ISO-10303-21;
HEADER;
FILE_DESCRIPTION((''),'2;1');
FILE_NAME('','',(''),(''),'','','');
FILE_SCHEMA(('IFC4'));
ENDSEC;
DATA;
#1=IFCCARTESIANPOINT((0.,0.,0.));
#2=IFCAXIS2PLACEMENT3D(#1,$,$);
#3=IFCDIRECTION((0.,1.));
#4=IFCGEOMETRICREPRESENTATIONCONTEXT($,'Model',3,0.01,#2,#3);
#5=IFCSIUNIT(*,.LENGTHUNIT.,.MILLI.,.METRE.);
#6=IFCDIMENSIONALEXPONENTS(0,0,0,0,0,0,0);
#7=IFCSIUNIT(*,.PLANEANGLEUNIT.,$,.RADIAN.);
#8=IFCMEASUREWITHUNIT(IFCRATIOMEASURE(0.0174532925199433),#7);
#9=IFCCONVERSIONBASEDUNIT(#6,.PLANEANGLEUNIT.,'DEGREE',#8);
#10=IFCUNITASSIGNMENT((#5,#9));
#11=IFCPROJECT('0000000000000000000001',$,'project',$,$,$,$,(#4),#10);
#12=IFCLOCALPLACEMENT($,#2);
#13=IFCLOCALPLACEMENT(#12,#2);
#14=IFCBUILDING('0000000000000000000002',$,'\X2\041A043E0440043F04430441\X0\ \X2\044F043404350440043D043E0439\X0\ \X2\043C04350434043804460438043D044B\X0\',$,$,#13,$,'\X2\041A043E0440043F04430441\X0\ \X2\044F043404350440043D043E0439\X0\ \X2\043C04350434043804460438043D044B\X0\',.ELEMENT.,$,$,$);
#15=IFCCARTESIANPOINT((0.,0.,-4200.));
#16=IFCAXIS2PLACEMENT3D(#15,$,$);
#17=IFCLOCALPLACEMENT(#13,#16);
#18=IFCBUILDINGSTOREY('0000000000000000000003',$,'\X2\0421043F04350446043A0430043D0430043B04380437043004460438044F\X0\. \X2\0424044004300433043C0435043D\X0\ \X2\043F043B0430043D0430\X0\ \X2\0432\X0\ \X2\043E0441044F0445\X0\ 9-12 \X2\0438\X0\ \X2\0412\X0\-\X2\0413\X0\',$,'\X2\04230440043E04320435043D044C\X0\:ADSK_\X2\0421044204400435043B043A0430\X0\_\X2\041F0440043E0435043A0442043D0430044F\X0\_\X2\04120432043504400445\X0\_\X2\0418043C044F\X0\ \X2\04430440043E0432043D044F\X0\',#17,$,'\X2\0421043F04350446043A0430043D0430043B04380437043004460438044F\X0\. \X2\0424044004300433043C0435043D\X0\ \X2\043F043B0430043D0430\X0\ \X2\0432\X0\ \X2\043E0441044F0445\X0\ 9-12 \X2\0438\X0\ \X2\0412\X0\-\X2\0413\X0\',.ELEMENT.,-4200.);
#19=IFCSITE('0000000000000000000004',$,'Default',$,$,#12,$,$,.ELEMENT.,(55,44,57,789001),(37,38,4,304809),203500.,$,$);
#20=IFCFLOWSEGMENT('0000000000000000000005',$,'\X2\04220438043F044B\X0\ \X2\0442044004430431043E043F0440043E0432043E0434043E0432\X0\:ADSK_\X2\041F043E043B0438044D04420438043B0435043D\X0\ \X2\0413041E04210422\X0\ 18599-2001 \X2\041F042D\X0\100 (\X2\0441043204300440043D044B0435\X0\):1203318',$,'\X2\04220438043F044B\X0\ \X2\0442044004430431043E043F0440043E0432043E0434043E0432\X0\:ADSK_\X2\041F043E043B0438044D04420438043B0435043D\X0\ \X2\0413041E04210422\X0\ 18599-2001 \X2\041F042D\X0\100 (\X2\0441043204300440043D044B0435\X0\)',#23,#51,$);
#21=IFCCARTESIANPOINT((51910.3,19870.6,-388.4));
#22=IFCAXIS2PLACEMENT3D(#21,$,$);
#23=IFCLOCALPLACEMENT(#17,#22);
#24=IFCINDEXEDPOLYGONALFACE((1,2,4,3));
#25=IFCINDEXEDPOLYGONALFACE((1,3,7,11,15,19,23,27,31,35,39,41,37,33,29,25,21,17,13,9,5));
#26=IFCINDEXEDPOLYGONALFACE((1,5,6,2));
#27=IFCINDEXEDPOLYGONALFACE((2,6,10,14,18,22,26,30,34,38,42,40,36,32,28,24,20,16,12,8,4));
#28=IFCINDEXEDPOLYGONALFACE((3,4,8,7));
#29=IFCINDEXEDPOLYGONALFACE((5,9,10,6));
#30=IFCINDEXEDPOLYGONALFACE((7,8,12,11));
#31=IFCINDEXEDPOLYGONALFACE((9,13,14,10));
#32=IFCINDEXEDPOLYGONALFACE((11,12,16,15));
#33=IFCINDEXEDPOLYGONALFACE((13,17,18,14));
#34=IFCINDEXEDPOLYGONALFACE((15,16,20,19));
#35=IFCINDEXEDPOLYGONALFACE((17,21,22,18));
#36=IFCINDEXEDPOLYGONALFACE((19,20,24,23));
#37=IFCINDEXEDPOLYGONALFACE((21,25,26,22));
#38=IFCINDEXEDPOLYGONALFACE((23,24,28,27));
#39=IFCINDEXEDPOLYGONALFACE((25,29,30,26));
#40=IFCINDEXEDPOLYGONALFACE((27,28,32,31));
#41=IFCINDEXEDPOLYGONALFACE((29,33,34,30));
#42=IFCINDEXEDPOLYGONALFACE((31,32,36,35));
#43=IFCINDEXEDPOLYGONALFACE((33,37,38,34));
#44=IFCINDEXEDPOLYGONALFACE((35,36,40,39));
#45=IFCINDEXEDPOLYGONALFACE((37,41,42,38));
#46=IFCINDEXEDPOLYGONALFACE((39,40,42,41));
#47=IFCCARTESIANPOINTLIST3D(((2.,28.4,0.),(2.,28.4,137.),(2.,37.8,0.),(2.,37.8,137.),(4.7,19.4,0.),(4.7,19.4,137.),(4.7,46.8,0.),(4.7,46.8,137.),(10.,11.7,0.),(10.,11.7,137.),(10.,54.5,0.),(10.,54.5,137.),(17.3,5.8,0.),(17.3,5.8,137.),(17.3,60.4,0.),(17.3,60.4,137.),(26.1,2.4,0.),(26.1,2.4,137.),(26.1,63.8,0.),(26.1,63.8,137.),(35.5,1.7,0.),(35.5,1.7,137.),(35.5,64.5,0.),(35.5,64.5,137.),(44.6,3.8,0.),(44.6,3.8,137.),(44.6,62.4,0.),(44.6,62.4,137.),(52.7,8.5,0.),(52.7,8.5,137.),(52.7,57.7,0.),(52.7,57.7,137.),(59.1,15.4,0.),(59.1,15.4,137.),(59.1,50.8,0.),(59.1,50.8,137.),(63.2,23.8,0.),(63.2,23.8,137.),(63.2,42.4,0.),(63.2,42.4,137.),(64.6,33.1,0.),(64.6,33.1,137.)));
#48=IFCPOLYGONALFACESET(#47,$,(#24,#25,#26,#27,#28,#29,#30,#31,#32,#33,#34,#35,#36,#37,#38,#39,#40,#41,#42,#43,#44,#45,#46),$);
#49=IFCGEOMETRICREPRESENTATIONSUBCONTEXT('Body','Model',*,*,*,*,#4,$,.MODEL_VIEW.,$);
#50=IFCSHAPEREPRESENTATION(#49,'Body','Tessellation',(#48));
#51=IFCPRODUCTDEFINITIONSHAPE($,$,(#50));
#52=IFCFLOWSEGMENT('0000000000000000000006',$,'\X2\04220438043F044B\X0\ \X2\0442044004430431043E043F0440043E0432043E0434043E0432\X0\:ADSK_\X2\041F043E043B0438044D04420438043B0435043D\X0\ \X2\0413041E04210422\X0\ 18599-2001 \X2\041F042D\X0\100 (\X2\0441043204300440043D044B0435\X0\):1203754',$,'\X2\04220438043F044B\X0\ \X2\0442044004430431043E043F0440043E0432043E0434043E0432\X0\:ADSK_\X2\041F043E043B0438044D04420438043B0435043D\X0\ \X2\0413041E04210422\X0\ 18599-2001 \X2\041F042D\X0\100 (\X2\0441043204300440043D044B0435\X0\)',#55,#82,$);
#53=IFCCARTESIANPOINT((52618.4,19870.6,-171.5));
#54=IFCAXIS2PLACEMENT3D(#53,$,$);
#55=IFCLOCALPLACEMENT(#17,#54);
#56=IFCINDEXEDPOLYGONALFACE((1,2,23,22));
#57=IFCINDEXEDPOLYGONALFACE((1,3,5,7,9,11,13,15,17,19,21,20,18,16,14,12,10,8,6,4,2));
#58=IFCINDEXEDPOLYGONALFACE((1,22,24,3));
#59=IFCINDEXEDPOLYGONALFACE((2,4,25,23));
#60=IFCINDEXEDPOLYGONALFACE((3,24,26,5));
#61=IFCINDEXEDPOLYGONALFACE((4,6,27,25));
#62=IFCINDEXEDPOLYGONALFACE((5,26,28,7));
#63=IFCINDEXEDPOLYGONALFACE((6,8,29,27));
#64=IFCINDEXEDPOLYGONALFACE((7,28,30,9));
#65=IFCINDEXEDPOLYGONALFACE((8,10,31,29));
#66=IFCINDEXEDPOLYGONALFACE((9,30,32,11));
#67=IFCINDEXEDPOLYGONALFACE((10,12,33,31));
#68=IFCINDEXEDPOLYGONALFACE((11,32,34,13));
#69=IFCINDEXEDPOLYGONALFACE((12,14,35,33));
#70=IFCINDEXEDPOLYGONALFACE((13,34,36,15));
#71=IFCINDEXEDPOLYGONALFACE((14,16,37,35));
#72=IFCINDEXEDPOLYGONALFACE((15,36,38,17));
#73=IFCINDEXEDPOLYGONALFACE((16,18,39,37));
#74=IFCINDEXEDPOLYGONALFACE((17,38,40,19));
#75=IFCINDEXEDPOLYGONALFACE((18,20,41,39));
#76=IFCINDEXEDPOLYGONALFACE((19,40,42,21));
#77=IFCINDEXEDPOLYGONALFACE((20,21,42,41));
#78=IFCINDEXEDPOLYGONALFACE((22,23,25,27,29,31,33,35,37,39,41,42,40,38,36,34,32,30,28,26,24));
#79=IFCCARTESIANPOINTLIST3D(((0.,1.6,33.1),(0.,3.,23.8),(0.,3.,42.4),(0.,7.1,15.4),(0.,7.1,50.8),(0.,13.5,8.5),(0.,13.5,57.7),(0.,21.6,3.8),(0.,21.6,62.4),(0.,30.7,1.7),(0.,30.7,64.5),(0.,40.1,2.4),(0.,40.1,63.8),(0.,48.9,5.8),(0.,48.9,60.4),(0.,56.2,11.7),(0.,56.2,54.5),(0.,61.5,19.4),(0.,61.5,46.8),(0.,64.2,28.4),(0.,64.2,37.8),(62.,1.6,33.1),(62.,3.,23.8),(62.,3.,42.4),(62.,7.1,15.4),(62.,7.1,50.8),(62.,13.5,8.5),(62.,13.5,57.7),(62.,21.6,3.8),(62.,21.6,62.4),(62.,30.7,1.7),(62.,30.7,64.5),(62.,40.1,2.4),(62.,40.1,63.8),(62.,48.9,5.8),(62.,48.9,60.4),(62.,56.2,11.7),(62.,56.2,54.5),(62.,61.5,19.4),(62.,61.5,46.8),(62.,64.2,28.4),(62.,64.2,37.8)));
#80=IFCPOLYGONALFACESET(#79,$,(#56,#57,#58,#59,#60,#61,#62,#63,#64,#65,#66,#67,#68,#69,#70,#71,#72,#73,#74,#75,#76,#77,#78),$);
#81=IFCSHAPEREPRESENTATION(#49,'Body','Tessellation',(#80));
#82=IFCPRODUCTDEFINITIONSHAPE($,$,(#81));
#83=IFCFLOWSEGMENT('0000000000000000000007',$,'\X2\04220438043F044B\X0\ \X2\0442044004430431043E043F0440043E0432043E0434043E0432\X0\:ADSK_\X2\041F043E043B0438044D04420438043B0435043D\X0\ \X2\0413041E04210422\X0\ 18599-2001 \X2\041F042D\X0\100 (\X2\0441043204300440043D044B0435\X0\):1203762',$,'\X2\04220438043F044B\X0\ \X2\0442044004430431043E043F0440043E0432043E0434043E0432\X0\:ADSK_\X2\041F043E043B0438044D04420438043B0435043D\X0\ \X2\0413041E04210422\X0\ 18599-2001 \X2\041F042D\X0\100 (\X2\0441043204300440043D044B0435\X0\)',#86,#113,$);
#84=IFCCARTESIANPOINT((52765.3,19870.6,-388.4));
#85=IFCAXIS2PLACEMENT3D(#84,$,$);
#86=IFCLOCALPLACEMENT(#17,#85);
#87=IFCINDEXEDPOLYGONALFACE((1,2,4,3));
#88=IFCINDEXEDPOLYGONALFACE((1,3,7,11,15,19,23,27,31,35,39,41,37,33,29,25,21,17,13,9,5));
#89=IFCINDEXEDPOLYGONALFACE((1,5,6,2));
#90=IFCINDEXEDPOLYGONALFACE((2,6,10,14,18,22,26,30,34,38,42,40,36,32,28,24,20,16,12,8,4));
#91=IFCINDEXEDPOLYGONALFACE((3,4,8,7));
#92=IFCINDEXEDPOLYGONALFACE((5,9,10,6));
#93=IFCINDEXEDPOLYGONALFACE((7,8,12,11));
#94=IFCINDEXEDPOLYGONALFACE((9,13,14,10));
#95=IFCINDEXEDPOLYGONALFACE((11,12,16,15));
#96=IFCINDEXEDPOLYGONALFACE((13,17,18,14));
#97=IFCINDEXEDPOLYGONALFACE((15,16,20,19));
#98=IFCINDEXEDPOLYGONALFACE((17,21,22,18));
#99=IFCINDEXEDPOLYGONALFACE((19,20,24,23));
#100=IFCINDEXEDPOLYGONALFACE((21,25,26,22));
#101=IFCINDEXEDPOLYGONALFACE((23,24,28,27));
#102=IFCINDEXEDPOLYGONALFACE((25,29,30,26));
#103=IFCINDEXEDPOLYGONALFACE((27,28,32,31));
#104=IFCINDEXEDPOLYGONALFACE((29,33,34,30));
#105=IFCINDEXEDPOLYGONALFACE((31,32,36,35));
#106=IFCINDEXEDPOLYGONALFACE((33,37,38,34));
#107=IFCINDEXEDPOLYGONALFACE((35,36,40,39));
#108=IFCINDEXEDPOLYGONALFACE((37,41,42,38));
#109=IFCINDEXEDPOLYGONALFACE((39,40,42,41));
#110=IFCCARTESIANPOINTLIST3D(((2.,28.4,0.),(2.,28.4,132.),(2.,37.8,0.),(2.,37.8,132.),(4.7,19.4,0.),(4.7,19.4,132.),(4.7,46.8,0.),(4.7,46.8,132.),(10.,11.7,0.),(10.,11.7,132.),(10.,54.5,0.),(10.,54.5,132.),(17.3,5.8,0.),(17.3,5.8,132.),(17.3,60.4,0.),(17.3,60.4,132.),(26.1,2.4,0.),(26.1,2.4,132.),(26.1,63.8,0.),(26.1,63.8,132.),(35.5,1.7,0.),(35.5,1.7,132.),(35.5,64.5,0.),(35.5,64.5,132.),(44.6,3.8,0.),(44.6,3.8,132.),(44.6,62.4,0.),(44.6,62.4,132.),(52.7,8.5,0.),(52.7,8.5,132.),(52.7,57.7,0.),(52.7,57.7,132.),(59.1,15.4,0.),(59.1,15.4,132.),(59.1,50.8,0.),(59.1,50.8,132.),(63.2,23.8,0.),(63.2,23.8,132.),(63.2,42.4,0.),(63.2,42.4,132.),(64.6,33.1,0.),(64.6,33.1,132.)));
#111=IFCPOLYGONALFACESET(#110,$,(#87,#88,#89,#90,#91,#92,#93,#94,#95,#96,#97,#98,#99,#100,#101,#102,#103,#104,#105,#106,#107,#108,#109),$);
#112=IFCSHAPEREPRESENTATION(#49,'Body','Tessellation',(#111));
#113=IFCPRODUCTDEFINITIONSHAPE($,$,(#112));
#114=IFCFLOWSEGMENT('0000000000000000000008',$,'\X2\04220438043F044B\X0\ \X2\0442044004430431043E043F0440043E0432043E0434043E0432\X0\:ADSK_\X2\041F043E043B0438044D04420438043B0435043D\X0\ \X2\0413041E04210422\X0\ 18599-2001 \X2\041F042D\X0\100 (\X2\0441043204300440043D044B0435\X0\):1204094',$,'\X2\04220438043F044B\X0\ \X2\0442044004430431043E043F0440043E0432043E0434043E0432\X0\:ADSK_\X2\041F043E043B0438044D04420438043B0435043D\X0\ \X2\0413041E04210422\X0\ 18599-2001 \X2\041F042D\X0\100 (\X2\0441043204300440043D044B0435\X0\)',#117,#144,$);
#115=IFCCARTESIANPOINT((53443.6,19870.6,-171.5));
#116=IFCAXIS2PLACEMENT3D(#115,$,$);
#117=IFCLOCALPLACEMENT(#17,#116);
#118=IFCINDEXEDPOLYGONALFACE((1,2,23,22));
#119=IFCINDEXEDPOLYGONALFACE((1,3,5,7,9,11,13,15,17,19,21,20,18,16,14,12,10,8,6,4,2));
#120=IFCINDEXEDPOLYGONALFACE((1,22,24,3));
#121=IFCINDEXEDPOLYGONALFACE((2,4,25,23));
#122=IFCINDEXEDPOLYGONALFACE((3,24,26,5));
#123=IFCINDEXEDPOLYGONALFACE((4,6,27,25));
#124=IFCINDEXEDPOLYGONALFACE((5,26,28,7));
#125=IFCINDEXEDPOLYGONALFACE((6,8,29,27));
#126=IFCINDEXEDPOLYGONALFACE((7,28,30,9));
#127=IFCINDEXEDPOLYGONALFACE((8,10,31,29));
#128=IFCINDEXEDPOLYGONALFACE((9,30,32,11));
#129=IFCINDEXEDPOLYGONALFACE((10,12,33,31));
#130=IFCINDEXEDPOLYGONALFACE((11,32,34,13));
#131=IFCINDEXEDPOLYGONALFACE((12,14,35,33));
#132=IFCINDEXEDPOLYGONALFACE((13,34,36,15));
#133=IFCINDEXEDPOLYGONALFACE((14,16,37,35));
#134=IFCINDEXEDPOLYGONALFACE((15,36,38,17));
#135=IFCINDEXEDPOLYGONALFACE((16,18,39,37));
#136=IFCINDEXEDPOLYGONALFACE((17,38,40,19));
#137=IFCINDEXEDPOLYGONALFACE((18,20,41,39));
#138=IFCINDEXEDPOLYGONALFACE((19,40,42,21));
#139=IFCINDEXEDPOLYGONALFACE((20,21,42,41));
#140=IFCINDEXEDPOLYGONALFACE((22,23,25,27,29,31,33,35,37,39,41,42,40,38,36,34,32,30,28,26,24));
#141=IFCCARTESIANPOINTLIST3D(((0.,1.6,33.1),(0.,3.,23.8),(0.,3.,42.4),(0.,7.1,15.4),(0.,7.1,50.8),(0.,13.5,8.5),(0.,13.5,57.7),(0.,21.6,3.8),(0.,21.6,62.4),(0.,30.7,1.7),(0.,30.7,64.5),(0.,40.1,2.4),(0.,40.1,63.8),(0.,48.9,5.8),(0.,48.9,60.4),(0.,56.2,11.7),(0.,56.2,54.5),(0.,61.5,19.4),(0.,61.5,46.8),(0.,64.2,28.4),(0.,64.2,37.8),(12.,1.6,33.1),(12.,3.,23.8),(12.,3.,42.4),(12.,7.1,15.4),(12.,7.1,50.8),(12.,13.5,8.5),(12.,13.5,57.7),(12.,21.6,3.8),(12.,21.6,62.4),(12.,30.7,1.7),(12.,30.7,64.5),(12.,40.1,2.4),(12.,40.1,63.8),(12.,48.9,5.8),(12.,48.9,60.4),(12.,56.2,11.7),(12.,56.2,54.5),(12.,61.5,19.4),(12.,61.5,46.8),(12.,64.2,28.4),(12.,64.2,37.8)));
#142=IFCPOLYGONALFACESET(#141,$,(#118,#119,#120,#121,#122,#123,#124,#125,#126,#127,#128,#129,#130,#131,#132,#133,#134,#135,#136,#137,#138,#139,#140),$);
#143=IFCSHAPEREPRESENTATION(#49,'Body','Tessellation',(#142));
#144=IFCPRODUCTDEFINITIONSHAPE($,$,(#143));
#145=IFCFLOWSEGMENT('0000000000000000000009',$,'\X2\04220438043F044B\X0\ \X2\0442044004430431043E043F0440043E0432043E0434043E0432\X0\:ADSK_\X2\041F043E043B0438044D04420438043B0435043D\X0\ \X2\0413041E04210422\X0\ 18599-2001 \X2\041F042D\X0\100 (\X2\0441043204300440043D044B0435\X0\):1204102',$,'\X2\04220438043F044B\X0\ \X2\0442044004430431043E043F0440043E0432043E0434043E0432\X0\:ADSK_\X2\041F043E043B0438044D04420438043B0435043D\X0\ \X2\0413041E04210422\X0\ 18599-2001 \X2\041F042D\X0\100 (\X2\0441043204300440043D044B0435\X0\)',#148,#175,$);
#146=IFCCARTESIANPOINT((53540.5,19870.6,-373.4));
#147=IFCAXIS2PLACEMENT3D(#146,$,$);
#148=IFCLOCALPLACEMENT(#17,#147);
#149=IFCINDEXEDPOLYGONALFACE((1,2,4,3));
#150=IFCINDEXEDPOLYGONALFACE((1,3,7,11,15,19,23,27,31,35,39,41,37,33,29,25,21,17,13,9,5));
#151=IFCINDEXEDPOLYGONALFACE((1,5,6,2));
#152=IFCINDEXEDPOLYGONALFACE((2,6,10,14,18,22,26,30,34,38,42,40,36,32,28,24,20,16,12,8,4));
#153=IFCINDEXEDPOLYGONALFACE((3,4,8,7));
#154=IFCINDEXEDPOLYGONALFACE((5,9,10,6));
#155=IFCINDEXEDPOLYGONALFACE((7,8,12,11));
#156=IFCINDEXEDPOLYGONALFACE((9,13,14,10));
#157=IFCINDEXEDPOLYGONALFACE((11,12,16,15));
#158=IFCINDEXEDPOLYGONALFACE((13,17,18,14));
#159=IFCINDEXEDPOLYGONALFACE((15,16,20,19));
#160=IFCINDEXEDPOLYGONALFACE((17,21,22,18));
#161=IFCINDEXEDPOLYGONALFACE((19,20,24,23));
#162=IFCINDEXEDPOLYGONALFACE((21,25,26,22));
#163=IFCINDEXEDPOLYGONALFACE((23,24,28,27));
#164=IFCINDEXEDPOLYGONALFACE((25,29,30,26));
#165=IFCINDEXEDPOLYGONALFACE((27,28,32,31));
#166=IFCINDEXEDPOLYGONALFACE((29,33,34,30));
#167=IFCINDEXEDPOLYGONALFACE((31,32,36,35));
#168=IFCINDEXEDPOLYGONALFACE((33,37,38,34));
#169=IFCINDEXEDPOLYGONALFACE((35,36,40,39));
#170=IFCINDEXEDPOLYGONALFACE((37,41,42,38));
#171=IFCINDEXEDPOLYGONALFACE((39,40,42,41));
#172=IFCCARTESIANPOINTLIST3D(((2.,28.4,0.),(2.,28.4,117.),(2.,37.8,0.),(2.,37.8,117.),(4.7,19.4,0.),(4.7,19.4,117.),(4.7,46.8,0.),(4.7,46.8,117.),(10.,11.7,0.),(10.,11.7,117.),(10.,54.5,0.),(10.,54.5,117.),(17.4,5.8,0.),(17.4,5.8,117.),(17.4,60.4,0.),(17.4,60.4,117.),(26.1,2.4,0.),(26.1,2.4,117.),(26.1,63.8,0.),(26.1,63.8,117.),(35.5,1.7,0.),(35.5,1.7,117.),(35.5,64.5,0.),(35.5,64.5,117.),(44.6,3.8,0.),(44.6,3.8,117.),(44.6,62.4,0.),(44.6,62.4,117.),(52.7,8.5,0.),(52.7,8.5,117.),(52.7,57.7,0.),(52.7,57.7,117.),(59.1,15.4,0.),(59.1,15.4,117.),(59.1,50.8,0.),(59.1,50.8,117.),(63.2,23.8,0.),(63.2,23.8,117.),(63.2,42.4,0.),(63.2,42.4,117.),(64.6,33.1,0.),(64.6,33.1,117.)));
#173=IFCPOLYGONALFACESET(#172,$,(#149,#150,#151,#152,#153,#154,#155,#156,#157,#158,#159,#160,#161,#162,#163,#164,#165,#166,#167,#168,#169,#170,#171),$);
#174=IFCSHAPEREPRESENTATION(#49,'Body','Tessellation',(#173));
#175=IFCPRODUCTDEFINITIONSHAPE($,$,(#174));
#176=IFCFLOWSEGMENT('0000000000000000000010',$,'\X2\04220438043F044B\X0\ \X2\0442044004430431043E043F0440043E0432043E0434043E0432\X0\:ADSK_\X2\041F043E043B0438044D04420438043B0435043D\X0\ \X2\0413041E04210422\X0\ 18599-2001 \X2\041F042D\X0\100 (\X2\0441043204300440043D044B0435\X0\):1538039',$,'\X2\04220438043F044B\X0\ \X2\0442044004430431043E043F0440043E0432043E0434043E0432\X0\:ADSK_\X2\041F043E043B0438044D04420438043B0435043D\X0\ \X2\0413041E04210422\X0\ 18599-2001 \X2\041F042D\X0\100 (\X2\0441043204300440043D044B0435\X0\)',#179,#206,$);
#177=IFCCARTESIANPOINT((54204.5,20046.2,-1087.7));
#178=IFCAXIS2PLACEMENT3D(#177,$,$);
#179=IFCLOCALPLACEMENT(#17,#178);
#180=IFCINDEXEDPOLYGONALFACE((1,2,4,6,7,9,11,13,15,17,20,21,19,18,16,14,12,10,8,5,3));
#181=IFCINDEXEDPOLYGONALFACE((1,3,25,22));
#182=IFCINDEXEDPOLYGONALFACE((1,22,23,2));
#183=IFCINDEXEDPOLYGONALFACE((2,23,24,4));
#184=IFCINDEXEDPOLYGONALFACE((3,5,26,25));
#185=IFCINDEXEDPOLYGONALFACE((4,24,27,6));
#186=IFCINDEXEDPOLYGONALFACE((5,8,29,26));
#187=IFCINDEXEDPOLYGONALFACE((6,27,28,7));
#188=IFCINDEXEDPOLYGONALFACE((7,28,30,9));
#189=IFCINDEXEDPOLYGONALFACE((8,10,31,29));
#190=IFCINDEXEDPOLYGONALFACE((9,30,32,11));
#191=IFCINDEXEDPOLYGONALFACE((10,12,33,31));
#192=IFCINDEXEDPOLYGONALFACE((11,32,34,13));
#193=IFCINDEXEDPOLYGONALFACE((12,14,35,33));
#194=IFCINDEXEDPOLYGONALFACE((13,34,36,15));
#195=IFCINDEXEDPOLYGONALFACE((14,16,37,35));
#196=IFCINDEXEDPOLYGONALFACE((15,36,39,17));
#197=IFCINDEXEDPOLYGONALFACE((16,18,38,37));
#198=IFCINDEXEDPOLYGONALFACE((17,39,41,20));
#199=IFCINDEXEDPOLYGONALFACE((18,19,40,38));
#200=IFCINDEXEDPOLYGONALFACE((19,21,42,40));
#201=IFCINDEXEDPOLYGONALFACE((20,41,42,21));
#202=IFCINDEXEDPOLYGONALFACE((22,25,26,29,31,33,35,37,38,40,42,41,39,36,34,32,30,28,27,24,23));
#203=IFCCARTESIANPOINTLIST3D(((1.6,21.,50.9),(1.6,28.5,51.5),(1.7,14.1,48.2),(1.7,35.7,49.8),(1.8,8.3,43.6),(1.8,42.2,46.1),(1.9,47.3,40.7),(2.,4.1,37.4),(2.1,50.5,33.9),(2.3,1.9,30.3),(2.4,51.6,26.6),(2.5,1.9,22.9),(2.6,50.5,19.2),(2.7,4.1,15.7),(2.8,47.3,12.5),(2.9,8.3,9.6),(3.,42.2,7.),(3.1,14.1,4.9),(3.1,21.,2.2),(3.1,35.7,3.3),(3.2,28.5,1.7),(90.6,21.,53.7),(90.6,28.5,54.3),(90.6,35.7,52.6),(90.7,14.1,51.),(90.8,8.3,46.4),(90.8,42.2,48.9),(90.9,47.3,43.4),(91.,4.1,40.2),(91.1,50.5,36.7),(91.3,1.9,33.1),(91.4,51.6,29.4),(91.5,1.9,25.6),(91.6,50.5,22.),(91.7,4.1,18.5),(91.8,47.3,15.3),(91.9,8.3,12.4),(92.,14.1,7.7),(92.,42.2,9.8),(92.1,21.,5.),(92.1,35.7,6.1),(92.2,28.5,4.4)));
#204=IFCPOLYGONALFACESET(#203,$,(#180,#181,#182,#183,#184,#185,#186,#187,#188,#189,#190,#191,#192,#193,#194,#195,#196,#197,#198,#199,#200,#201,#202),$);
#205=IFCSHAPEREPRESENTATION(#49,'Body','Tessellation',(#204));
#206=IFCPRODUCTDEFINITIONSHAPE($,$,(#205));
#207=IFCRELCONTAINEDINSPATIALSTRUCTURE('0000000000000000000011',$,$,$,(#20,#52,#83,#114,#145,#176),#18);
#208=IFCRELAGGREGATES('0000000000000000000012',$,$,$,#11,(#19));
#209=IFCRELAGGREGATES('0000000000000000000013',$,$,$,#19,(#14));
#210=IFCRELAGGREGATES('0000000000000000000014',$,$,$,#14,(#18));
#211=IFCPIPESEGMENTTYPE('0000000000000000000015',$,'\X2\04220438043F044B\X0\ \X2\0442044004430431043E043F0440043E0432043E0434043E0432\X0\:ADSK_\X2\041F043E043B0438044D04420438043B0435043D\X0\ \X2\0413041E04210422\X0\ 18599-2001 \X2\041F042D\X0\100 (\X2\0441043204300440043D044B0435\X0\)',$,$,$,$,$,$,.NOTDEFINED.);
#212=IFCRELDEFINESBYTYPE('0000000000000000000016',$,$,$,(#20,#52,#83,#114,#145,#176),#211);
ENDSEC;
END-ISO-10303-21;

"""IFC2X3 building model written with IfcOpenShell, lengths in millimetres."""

from ifc_helpers import new_model, entity, si_unit, converted_unit, direction, frame, origin, origin_2d_with_axis, place, context, subcontext, project, spatial, circle, extrude, type_object, element, save


model = new_model("IFC2X3")

# Units and contexts
model_context = context("Model", 3, precision=0.01, world=origin(), true_north=direction((0.0, 1.0)))
body_context = subcontext(model_context, "Body", "Model", "MODEL_VIEW")
ifc_project = project(units=[si_unit("LENGTHUNIT", "METRE", prefix="MILLI"), converted_unit("PLANEANGLEUNIT", "DEGREE", entity("IfcRatioMeasure", 0.0174532925199433), si_unit("PLANEANGLEUNIT", "RADIAN"), dimensions=[0, 0, 0, 0, 0, 0, 0])], contexts=[model_context])

# Site, building, storey
site_placement = place(None, origin())
site = spatial("IfcSite", under=ifc_project, at=site_placement, Name="Default", CompositionType="ELEMENT", RefLatitude=(55, 44, 57, 789001), RefLongitude=(37, 38, 4, 304809), RefElevation=203500.0)
building_placement = place(site_placement, origin())
building = spatial("IfcBuilding", under=site, at=building_placement, Name="Корпус ядерной медицины", LongName="Корпус ядерной медицины", CompositionType="ELEMENT")
storey_placement = place(building_placement, frame((0.0, 0.0, -4200.0)))
storey = spatial("IfcBuildingStorey", under=building, at=storey_placement, Name="Спецканализация. Фрагмен плана в осях 9-12 и В-Г", ObjectType="Уровень:ADSK_Стрелка_Проектная_Вверх_Имя уровня", LongName="Спецканализация. Фрагмен плана в осях 9-12 и В-Г", CompositionType="ELEMENT", Elevation=-4200.0)

# Flow segments
pipe_segment_type = type_object("IfcPipeSegmentType", Name="Типы трубопроводов:ADSK_Полиэтилен ГОСТ 18599-2001 ПЭ100 (сварные)", PredefinedType="NOTDEFINED")
flow_segment_1_placement = place(storey_placement, frame((51910.3, 19870.6, -388.4)))
element("IfcFlowSegment", 1, at=flow_segment_1_placement, inside=storey, type_object=pipe_segment_type, Name="Типы трубопроводов:ADSK_Полиэтилен ГОСТ 18599-2001 ПЭ100 (сварные):1203318", ObjectType="Типы трубопроводов:ADSK_Полиэтилен ГОСТ 18599-2001 ПЭ100 (сварные)", context=body_context, shape_type="SweptSolid", body=[
    extrude(circle(Radius=31.5, at=origin_2d_with_axis()), frame((33.1, 33.1, 0.0)), (0.0, 0.0, 1.0), 137.0),
])
flow_segment_2_placement = place(storey_placement, frame((52618.4, 19870.6, -171.5)))
element("IfcFlowSegment", 2, at=flow_segment_2_placement, inside=storey, type_object=pipe_segment_type, Name="Типы трубопроводов:ADSK_Полиэтилен ГОСТ 18599-2001 ПЭ100 (сварные):1203754", ObjectType="Типы трубопроводов:ADSK_Полиэтилен ГОСТ 18599-2001 ПЭ100 (сварные)", context=body_context, shape_type="SweptSolid", body=[
    extrude(circle(Radius=31.5, at=origin_2d_with_axis()), frame((0.0, 33.1, 33.1), z_axis=(1.0, 0.0, 0.0), x_axis=(0.0, -1.0, 0.0)), (0.0, 0.0, 1.0), 62.0),
])
flow_segment_3_placement = place(storey_placement, frame((52765.3, 19870.6, -388.4)))
element("IfcFlowSegment", 3, at=flow_segment_3_placement, inside=storey, type_object=pipe_segment_type, Name="Типы трубопроводов:ADSK_Полиэтилен ГОСТ 18599-2001 ПЭ100 (сварные):1203762", ObjectType="Типы трубопроводов:ADSK_Полиэтилен ГОСТ 18599-2001 ПЭ100 (сварные)", context=body_context, shape_type="SweptSolid", body=[
    extrude(circle(Radius=31.5, at=origin_2d_with_axis()), frame((33.1, 33.1, 0.0)), (0.0, 0.0, 1.0), 132.0),
])
flow_segment_4_placement = place(storey_placement, frame((53443.6, 19870.6, -171.5)))
element("IfcFlowSegment", 4, at=flow_segment_4_placement, inside=storey, type_object=pipe_segment_type, Name="Типы трубопроводов:ADSK_Полиэтилен ГОСТ 18599-2001 ПЭ100 (сварные):1204094", ObjectType="Типы трубопроводов:ADSK_Полиэтилен ГОСТ 18599-2001 ПЭ100 (сварные)", context=body_context, shape_type="SweptSolid", body=[
    extrude(circle(Radius=31.5, at=origin_2d_with_axis()), frame((0.0, 33.1, 33.1), z_axis=(1.0, 0.0, 0.0), x_axis=(0.0, -1.0, 0.0)), (0.0, 0.0, 1.0), 12.0),
])
flow_segment_5_placement = place(storey_placement, frame((53540.5, 19870.6, -373.4)))
element("IfcFlowSegment", 5, at=flow_segment_5_placement, inside=storey, type_object=pipe_segment_type, Name="Типы трубопроводов:ADSK_Полиэтилен ГОСТ 18599-2001 ПЭ100 (сварные):1204102", ObjectType="Типы трубопроводов:ADSK_Полиэтилен ГОСТ 18599-2001 ПЭ100 (сварные)", context=body_context, shape_type="SweptSolid", body=[
    extrude(circle(Radius=31.5, at=origin_2d_with_axis()), frame((33.1, 33.1, 0.0)), (0.0, 0.0, 1.0), 117.0),
])
flow_segment_6_placement = place(storey_placement, frame((54204.5, 20046.2, -1087.7)))
element("IfcFlowSegment", 6, at=flow_segment_6_placement, inside=storey, type_object=pipe_segment_type, Name="Типы трубопроводов:ADSK_Полиэтилен ГОСТ 18599-2001 ПЭ100 (сварные):1538039", ObjectType="Типы трубопроводов:ADSK_Полиэтилен ГОСТ 18599-2001 ПЭ100 (сварные)", context=body_context, shape_type="SweptSolid", body=[
    extrude(circle(Radius=25.0, at=origin_2d_with_axis()), frame((2.4, 26.6, 26.6), z_axis=(0.99951, 0.0, 0.031299), x_axis=(0.0, 1.0, 0.0)), (0.0, 0.0, 1.0), 89.0),
])

save(model, "model.ifc")
